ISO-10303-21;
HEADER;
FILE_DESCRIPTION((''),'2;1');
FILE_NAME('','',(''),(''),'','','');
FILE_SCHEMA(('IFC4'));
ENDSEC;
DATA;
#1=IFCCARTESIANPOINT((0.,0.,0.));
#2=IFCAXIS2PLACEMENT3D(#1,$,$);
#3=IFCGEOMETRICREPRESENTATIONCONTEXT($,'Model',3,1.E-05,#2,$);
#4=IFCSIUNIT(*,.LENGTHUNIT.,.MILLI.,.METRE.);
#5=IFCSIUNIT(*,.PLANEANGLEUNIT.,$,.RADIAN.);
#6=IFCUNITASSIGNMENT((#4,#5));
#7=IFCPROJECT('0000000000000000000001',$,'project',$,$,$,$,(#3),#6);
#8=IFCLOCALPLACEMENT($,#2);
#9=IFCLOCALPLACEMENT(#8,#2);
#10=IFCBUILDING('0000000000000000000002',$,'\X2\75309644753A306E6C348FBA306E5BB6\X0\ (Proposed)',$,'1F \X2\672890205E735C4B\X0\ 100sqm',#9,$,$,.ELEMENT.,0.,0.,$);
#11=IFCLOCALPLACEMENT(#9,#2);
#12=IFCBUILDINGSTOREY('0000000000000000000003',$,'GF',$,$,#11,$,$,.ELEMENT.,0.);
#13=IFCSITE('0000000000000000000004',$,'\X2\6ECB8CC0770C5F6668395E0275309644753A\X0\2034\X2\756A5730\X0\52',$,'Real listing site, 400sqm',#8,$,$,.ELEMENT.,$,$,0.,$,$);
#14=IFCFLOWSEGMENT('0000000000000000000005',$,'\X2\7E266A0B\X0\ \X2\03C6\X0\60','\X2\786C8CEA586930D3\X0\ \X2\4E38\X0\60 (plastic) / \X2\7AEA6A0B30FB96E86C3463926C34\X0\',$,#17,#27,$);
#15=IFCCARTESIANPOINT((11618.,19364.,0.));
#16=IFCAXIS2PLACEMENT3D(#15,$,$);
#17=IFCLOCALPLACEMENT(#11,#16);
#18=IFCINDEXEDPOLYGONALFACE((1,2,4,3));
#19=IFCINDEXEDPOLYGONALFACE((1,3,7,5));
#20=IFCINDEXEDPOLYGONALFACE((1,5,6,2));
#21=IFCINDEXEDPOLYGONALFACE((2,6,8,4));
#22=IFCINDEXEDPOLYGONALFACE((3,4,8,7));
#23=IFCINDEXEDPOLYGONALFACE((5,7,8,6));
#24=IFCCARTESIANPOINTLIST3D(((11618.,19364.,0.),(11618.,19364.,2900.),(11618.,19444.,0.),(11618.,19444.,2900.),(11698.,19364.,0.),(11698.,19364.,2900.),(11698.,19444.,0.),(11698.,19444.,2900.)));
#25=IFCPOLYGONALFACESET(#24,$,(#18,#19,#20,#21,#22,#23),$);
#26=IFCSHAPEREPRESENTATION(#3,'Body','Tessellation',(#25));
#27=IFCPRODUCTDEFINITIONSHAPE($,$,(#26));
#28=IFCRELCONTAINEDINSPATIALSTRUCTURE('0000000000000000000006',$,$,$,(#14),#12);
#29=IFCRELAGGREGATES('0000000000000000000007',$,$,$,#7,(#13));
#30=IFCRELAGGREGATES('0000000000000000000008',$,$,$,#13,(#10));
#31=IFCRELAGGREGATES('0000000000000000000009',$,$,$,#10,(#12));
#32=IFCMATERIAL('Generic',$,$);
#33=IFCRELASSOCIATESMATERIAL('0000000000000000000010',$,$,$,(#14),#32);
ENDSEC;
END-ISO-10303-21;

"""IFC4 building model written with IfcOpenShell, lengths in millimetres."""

from ifc_helpers import new_model, si_unit, frame, frame_2d, origin, place, context, project, spatial, rectangle, extrude, material, element, save


model = new_model("IFC4")

# Units and contexts
model_context = context("Model", 3, precision=1e-05, world=origin())
ifc_project = project(units=[si_unit("LENGTHUNIT", "METRE", prefix="MILLI"), si_unit("PLANEANGLEUNIT", "RADIAN")], contexts=[model_context])

# Site, building, storey
site_placement = place(None, origin())
site = spatial("IfcSite", under=ifc_project, at=site_placement, Name="滋賀県彦根市田附町2034番地52", ObjectType="Real listing site, 400sqm", CompositionType="ELEMENT", RefElevation=0.0)
building_placement = place(site_placement, origin())
building = spatial("IfcBuilding", under=site, at=building_placement, Name="田附町の水辺の家 (Proposed)", ObjectType="1F 木造平屋 100sqm", CompositionType="ELEMENT", ElevationOfRefHeight=0.0, ElevationOfTerrain=0.0)
storey_placement = place(building_placement, origin())
storey = spatial("IfcBuildingStorey", under=building, at=storey_placement, Name="GF", CompositionType="ELEMENT", Elevation=0.0)

# Shared definitions
ifc_material_1 = material(Name="Generic")

# Flow segment
flow_segment_placement = place(storey_placement, frame((11618.0, 19364.0, 0.0)))
element("IfcFlowSegment", 1, at=flow_segment_placement, inside=storey, material=ifc_material_1, Name="縦樋 φ60", Description="硬質塩ビ 丸60 (plastic) / 竪樋・雨水排水", context=model_context, shape_type="SweptSolid", body=[
    extrude(rectangle(XDim=80.0, YDim=80.0, at=frame_2d((40.0, 40.0))), frame((11618.0, 19364.0, 0.0)), (0.0, 0.0, 1.0), 2900.0),
])

save(model, "model.ifc")
